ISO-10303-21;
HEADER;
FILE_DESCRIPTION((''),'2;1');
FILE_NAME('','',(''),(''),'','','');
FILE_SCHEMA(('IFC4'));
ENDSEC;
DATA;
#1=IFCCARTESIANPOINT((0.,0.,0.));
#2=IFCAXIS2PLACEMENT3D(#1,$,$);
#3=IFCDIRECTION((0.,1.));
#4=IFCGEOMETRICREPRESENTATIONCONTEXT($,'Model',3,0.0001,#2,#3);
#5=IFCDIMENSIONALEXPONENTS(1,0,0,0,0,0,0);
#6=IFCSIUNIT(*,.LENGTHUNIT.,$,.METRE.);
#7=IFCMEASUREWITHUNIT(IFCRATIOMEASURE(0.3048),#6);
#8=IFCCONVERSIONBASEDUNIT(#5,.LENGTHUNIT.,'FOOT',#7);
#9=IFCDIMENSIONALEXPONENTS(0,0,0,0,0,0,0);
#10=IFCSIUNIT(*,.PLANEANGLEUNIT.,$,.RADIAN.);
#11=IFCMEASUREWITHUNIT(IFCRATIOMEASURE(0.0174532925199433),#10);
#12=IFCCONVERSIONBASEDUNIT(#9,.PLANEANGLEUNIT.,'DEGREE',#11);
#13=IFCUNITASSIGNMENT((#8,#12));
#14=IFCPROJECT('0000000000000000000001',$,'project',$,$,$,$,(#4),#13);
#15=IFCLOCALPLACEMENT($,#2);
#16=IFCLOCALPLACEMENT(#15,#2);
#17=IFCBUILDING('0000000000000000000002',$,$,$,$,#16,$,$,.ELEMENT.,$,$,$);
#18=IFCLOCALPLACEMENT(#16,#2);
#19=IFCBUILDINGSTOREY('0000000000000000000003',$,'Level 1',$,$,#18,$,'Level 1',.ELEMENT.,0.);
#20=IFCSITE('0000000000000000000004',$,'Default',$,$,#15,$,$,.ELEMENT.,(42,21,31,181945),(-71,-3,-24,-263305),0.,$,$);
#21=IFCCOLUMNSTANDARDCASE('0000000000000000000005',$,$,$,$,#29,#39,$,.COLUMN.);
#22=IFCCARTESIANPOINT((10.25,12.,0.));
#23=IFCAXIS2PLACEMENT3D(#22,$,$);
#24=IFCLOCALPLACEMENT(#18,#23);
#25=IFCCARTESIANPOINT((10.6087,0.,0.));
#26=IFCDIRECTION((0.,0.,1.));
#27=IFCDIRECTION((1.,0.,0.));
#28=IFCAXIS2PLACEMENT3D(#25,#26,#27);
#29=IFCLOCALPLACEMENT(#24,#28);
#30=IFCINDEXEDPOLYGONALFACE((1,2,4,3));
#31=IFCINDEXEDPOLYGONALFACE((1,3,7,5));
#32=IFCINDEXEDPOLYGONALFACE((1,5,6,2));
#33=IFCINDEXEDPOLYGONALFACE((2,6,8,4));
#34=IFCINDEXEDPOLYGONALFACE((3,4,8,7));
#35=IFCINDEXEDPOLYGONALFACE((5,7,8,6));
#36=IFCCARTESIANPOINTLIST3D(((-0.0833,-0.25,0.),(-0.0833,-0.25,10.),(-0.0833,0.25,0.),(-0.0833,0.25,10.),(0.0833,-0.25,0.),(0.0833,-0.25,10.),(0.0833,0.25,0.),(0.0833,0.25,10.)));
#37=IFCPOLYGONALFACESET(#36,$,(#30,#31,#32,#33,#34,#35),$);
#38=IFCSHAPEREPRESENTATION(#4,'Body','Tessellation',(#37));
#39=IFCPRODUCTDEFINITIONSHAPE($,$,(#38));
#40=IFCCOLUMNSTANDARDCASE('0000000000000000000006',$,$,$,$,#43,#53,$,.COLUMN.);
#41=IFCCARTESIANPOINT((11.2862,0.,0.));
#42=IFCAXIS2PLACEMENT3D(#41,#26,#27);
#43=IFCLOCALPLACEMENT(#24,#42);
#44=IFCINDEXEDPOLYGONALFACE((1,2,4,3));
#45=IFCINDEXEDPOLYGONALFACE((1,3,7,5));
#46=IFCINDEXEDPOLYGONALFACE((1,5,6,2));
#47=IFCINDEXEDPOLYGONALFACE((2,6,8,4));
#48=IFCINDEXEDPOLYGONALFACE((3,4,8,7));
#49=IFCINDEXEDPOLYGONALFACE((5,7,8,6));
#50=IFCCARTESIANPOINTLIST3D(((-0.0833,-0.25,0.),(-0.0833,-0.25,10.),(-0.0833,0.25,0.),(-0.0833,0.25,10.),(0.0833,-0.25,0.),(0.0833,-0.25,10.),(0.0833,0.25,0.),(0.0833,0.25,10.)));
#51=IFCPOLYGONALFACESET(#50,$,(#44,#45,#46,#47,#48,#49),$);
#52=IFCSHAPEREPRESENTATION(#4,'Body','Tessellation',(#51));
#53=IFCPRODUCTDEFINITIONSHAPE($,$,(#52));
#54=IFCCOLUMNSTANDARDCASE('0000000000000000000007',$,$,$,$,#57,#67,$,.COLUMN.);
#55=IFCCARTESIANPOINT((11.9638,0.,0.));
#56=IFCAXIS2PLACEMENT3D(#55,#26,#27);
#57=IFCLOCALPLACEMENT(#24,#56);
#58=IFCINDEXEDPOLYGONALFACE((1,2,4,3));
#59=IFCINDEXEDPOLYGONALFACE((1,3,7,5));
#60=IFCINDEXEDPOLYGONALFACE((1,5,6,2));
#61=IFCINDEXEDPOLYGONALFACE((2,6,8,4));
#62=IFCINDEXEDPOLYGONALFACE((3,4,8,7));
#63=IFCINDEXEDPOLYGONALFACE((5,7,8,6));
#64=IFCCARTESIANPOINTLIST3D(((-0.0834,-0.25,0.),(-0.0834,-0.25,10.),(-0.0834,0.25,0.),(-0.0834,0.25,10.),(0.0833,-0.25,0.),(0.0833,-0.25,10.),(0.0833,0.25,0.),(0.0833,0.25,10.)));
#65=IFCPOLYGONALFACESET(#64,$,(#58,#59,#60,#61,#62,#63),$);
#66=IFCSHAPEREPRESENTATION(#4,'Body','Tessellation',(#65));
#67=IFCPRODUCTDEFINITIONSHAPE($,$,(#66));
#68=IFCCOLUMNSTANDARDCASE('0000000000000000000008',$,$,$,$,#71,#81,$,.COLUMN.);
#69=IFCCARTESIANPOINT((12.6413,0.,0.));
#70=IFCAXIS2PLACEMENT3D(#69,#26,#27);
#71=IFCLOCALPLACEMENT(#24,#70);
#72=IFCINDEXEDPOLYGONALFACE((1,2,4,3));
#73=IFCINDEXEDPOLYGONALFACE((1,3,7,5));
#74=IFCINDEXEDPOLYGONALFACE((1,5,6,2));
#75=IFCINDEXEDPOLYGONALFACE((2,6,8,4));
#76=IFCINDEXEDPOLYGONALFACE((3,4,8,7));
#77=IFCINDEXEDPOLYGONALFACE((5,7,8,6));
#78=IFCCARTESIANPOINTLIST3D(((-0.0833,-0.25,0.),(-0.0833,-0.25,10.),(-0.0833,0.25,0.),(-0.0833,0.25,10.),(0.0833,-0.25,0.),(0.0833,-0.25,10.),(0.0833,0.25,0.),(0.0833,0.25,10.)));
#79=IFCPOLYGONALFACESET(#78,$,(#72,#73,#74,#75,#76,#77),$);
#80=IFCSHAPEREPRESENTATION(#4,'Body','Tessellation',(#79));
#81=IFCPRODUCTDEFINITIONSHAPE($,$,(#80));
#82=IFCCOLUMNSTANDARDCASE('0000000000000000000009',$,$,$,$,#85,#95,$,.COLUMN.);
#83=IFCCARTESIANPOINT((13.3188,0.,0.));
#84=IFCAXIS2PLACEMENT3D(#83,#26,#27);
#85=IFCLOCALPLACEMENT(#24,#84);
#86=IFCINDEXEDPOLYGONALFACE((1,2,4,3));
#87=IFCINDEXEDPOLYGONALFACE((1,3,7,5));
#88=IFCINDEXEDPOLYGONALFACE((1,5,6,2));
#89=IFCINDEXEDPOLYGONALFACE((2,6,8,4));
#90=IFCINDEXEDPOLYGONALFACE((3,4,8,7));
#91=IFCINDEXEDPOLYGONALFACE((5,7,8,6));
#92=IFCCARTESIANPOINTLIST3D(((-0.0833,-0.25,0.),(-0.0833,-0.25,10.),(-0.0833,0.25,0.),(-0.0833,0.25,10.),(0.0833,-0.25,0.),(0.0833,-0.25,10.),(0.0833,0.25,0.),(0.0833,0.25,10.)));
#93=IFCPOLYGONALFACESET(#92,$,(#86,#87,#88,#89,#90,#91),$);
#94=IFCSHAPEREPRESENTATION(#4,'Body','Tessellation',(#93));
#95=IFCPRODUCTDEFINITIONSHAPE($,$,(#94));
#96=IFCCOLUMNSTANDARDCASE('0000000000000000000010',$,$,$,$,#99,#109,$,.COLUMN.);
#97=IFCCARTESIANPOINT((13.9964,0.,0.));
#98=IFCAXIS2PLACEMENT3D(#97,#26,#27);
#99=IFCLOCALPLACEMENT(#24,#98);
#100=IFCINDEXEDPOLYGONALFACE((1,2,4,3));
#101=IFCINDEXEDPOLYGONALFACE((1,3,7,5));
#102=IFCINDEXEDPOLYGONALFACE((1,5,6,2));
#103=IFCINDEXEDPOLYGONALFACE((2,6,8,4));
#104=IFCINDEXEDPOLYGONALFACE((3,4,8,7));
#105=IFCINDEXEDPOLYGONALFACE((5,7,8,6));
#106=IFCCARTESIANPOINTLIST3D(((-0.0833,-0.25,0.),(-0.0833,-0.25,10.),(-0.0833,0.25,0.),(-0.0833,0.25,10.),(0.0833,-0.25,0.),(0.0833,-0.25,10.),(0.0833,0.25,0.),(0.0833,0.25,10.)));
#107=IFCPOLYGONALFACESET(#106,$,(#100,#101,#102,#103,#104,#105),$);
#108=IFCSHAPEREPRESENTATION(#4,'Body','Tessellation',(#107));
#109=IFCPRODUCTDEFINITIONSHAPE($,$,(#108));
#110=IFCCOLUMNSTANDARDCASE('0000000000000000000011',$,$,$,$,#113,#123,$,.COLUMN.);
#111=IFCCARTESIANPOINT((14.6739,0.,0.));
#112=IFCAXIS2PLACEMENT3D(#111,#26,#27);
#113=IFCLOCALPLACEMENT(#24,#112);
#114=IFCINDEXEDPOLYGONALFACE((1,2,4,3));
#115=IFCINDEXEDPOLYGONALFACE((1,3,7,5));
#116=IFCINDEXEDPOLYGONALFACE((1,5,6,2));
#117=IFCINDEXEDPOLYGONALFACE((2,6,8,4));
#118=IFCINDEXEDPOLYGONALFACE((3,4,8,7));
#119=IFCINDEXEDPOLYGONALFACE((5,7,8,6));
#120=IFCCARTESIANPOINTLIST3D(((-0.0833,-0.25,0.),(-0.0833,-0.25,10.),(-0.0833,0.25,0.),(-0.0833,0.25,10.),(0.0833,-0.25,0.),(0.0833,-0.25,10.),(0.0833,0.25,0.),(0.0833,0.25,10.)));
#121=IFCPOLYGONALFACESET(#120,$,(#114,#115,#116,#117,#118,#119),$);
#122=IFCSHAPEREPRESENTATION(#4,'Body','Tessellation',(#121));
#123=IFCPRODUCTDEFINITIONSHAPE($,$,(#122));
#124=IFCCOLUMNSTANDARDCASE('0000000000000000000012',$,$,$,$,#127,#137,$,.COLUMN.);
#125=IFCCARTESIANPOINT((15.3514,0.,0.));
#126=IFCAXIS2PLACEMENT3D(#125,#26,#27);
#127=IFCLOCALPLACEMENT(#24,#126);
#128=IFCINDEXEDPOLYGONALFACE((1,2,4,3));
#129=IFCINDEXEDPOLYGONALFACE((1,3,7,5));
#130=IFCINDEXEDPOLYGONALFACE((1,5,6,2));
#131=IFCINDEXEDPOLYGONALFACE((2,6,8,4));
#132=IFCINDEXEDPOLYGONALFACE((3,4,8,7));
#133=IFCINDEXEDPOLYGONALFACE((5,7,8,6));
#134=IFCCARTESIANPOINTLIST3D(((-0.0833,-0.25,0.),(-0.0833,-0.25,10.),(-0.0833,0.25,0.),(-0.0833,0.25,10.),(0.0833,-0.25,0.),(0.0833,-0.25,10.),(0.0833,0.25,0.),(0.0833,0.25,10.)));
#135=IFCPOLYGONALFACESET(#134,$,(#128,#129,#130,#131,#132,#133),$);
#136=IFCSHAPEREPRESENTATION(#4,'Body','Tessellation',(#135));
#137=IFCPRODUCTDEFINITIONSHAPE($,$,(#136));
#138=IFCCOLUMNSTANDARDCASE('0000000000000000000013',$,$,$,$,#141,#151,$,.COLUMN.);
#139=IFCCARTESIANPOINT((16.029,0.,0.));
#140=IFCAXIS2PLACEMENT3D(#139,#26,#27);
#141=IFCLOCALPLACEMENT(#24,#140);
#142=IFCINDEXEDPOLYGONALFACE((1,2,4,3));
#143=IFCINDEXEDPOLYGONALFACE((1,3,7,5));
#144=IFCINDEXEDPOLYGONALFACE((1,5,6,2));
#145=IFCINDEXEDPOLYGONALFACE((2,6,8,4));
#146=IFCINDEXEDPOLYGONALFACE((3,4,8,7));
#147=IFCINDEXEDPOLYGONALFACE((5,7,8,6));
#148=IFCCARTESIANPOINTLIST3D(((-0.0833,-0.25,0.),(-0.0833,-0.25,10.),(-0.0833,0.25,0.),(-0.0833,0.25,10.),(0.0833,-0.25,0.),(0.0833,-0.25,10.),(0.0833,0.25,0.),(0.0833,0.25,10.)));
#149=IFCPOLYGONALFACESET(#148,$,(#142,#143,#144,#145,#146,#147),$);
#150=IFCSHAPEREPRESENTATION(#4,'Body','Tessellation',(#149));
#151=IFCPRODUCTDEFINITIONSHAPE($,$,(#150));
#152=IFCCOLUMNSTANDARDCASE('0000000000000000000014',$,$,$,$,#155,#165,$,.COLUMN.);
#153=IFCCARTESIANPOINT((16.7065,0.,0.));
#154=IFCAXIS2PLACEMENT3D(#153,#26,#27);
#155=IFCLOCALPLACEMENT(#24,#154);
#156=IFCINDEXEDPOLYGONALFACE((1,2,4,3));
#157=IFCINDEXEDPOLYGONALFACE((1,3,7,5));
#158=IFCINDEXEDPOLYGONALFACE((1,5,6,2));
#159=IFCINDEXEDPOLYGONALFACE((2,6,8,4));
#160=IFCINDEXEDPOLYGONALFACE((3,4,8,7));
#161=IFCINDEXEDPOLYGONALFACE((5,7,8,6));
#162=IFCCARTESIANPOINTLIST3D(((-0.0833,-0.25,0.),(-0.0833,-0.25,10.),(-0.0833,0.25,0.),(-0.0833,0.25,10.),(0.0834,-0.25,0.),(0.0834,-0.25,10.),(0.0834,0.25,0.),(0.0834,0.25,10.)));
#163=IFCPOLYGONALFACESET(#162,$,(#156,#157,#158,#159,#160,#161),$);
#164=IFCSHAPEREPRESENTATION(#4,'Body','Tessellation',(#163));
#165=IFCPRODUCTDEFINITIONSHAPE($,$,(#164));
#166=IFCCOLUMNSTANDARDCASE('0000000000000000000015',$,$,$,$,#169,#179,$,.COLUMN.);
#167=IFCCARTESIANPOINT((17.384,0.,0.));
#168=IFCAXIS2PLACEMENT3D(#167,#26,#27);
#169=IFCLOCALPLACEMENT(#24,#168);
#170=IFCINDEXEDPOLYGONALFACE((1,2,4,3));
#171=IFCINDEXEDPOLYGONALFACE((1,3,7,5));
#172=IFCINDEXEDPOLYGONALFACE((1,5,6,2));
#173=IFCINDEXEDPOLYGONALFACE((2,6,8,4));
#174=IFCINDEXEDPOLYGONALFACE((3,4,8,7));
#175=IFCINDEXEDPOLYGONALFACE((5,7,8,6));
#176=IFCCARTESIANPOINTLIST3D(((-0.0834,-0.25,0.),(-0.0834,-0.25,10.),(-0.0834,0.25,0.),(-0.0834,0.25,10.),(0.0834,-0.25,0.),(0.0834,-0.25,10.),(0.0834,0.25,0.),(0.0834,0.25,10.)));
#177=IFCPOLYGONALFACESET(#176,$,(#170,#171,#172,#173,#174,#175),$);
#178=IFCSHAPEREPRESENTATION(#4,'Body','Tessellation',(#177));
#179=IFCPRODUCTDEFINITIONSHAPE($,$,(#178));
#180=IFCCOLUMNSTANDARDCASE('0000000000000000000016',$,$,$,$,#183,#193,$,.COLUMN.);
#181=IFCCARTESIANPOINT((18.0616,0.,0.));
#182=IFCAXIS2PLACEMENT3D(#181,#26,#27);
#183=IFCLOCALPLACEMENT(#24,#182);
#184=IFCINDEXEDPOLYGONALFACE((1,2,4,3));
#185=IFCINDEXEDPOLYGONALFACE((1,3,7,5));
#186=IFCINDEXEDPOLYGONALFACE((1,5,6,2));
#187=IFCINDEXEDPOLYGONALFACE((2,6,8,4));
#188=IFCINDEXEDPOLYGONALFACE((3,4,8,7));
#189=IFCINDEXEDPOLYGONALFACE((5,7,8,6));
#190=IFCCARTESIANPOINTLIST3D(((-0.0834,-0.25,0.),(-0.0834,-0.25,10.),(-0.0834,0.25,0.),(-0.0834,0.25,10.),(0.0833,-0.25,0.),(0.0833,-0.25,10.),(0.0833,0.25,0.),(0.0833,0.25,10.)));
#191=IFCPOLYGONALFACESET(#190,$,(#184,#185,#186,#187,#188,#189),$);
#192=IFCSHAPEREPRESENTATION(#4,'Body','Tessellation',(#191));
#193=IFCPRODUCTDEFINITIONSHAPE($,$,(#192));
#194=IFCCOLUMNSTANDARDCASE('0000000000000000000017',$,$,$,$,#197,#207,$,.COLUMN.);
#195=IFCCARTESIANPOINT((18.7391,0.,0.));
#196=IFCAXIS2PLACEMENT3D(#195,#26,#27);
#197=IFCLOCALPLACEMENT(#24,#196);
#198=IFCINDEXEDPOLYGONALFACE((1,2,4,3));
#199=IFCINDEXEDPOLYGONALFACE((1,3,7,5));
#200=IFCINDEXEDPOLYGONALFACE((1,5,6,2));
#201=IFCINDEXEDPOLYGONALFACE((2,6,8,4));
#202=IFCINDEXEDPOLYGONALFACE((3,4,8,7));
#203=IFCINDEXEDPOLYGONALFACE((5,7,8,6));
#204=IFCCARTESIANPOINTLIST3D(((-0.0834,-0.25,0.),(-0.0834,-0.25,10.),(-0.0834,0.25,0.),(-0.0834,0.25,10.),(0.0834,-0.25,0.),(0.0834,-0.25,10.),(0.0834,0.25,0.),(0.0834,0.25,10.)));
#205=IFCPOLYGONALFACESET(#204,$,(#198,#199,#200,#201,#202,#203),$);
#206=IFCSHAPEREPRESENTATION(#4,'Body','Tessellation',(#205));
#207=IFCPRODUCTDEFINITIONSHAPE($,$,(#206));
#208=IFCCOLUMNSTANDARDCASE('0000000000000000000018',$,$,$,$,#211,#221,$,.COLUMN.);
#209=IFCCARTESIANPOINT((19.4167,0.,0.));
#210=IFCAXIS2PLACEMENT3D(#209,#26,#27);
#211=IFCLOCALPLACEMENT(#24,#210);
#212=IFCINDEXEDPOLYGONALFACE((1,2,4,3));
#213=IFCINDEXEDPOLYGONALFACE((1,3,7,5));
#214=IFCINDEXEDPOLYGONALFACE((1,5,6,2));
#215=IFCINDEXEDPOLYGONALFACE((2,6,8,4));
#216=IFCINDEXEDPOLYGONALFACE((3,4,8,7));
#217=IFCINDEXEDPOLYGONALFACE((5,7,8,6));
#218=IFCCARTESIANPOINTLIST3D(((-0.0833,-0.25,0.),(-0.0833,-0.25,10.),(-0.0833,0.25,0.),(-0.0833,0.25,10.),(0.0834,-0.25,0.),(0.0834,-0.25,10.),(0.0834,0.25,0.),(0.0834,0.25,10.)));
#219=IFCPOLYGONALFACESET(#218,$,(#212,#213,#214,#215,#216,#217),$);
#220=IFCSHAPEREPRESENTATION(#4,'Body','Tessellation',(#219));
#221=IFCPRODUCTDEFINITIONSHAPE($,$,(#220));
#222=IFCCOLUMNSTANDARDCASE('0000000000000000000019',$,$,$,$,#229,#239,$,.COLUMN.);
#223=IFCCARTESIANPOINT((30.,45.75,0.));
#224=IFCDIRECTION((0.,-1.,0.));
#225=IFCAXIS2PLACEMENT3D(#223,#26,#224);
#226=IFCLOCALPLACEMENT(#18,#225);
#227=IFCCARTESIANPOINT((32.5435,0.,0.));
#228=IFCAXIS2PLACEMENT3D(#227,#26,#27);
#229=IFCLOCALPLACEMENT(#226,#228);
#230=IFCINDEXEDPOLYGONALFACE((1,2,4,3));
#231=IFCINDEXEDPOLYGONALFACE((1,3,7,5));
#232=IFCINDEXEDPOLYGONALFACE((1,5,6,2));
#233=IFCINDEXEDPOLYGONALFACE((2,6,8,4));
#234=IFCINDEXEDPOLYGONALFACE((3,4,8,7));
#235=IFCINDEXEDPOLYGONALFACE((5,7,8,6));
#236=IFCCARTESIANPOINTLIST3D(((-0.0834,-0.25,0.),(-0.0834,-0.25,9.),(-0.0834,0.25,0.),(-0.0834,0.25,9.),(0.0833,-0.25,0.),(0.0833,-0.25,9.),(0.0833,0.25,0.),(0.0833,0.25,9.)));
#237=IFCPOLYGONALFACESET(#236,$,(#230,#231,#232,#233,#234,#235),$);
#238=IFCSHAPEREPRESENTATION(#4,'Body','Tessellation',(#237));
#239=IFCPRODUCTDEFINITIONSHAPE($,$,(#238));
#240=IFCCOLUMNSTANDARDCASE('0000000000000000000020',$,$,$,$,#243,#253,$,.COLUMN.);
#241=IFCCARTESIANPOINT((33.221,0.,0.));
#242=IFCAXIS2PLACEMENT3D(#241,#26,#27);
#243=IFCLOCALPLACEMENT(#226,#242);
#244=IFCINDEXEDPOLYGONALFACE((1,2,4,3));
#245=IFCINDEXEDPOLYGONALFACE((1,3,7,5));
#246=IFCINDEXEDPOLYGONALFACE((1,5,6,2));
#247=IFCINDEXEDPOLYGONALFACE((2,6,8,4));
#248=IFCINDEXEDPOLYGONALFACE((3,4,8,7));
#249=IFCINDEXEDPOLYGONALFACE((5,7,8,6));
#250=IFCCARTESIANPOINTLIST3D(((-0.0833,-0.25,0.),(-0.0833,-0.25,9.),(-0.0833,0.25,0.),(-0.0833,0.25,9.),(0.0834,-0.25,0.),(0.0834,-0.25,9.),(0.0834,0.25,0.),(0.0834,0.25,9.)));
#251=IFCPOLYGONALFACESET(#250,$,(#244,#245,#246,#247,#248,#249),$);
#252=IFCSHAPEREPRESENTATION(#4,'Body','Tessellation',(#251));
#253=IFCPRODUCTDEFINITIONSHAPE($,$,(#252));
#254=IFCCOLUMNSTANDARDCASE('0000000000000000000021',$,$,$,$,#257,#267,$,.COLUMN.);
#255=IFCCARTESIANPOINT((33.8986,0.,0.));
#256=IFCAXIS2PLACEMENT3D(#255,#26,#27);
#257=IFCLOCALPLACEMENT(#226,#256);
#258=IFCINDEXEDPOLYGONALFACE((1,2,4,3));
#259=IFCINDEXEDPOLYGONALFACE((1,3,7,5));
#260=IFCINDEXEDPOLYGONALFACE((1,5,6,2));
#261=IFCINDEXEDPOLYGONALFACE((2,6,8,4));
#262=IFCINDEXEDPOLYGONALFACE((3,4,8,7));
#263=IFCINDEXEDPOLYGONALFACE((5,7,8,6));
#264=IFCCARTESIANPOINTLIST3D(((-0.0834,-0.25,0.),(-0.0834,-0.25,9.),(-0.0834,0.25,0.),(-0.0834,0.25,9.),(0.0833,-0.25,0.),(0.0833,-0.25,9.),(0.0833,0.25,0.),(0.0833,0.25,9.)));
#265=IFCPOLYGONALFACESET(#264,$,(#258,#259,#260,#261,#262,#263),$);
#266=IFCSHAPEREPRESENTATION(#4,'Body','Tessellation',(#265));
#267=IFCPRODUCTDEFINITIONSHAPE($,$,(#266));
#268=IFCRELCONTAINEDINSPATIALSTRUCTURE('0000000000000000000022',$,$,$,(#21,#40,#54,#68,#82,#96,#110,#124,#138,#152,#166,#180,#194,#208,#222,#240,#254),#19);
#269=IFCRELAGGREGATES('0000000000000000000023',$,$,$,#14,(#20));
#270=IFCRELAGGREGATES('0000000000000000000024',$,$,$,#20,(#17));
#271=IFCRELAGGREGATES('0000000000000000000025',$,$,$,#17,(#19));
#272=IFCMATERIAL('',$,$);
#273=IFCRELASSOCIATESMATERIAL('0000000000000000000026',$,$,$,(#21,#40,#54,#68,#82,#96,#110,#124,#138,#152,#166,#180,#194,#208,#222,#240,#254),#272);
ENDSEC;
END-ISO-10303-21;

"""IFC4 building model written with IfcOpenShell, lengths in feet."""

from ifc_helpers import new_model, entity, si_unit, converted_unit, direction, frame, origin, place, context, project, spatial, rectangle, extrude, material, element, save


model = new_model("IFC4")

# Units and contexts
model_context = context("Model", 3, precision=0.0001, world=origin(), true_north=direction((0.0, 1.0)))
ifc_project = project(units=[converted_unit("LENGTHUNIT", "FOOT", entity("IfcRatioMeasure", 0.3048), si_unit("LENGTHUNIT", "METRE"), dimensions=[1, 0, 0, 0, 0, 0, 0]), converted_unit("PLANEANGLEUNIT", "DEGREE", entity("IfcRatioMeasure", 0.0174532925199433), si_unit("PLANEANGLEUNIT", "RADIAN"), dimensions=[0, 0, 0, 0, 0, 0, 0])], contexts=[model_context])

# Site, building, storey
site_placement = place(None, origin())
site = spatial("IfcSite", under=ifc_project, at=site_placement, Name="Default", CompositionType="ELEMENT", RefLatitude=(42, 21, 31, 181945), RefLongitude=(-71, -3, -24, -263305), RefElevation=0.0)
building_placement = place(site_placement, origin())
building = spatial("IfcBuilding", under=site, at=building_placement, CompositionType="ELEMENT")
storey_placement = place(building_placement, origin())
storey = spatial("IfcBuildingStorey", under=building, at=storey_placement, Name="Level 1", LongName="Level 1", CompositionType="ELEMENT", Elevation=0.0)

# Columns
ifc_material = material(Name="")
placement_1 = place(storey_placement, frame((10.25, 12.0, 0.0)))
for number, where, z_axis, x_axis in (
    (1, (10.6087, 0.0, 0.0), (0.0, 0.0, 1.0), (1.0, 0.0, 0.0)),
    (2, (11.2862, 0.0, 0.0), (0.0, 0.0, 1.0), (1.0, 0.0, 0.0)),
    (3, (11.9638, 0.0, 0.0), (0.0, 0.0, 1.0), (1.0, 0.0, 0.0)),
    (4, (12.6413, 0.0, 0.0), (0.0, 0.0, 1.0), (1.0, 0.0, 0.0)),
    (5, (13.3188, 0.0, 0.0), (0.0, 0.0, 1.0), (1.0, 0.0, 0.0)),
    (6, (13.9964, 0.0, 0.0), (0.0, 0.0, 1.0), (1.0, 0.0, 0.0)),
    (7, (14.6739, 0.0, 0.0), (0.0, 0.0, 1.0), (1.0, 0.0, 0.0)),
    (8, (15.3514, 0.0, 0.0), (0.0, 0.0, 1.0), (1.0, 0.0, 0.0)),
    (9, (16.029, 0.0, 0.0), (0.0, 0.0, 1.0), (1.0, 0.0, 0.0)),
    (10, (16.7065, 0.0, 0.0), (0.0, 0.0, 1.0), (1.0, 0.0, 0.0)),
    (11, (17.384, 0.0, 0.0), (0.0, 0.0, 1.0), (1.0, 0.0, 0.0)),
    (12, (18.0616, 0.0, 0.0), (0.0, 0.0, 1.0), (1.0, 0.0, 0.0)),
    (13, (18.7391, 0.0, 0.0), (0.0, 0.0, 1.0), (1.0, 0.0, 0.0)),
    (14, (19.4167, 0.0, 0.0), (0.0, 0.0, 1.0), (1.0, 0.0, 0.0)),
):
    element("IfcColumnStandardCase", number, at=place(placement_1, frame(where, z_axis=z_axis, x_axis=x_axis)), inside=storey, material=ifc_material, PredefinedType="COLUMN", context=model_context, shape_type="SweptSolid", body=[
        extrude(rectangle(XDim=0.1667, YDim=0.5), origin(), (0.0, 0.0, 1.0), 10.0),
    ])
placement_2 = place(storey_placement, frame((30.0, 45.75, 0.0), z_axis=(0.0, 0.0, 1.0), x_axis=(0.0, -1.0, 0.0)))
for number, where, z_axis, x_axis in (
    (15, (32.5435, 0.0, 0.0), (0.0, 0.0, 1.0), (1.0, 0.0, 0.0)),
    (16, (33.221, 0.0, 0.0), (0.0, 0.0, 1.0), (1.0, 0.0, 0.0)),
    (17, (33.8986, 0.0, 0.0), (0.0, 0.0, 1.0), (1.0, 0.0, 0.0)),
):
    element("IfcColumnStandardCase", number, at=place(placement_2, frame(where, z_axis=z_axis, x_axis=x_axis)), inside=storey, material=ifc_material, PredefinedType="COLUMN", context=model_context, shape_type="SweptSolid", body=[
        extrude(rectangle(XDim=0.1667, YDim=0.5), origin(), (0.0, 0.0, 1.0), 9.0),
    ])

save(model, "model.ifc")
